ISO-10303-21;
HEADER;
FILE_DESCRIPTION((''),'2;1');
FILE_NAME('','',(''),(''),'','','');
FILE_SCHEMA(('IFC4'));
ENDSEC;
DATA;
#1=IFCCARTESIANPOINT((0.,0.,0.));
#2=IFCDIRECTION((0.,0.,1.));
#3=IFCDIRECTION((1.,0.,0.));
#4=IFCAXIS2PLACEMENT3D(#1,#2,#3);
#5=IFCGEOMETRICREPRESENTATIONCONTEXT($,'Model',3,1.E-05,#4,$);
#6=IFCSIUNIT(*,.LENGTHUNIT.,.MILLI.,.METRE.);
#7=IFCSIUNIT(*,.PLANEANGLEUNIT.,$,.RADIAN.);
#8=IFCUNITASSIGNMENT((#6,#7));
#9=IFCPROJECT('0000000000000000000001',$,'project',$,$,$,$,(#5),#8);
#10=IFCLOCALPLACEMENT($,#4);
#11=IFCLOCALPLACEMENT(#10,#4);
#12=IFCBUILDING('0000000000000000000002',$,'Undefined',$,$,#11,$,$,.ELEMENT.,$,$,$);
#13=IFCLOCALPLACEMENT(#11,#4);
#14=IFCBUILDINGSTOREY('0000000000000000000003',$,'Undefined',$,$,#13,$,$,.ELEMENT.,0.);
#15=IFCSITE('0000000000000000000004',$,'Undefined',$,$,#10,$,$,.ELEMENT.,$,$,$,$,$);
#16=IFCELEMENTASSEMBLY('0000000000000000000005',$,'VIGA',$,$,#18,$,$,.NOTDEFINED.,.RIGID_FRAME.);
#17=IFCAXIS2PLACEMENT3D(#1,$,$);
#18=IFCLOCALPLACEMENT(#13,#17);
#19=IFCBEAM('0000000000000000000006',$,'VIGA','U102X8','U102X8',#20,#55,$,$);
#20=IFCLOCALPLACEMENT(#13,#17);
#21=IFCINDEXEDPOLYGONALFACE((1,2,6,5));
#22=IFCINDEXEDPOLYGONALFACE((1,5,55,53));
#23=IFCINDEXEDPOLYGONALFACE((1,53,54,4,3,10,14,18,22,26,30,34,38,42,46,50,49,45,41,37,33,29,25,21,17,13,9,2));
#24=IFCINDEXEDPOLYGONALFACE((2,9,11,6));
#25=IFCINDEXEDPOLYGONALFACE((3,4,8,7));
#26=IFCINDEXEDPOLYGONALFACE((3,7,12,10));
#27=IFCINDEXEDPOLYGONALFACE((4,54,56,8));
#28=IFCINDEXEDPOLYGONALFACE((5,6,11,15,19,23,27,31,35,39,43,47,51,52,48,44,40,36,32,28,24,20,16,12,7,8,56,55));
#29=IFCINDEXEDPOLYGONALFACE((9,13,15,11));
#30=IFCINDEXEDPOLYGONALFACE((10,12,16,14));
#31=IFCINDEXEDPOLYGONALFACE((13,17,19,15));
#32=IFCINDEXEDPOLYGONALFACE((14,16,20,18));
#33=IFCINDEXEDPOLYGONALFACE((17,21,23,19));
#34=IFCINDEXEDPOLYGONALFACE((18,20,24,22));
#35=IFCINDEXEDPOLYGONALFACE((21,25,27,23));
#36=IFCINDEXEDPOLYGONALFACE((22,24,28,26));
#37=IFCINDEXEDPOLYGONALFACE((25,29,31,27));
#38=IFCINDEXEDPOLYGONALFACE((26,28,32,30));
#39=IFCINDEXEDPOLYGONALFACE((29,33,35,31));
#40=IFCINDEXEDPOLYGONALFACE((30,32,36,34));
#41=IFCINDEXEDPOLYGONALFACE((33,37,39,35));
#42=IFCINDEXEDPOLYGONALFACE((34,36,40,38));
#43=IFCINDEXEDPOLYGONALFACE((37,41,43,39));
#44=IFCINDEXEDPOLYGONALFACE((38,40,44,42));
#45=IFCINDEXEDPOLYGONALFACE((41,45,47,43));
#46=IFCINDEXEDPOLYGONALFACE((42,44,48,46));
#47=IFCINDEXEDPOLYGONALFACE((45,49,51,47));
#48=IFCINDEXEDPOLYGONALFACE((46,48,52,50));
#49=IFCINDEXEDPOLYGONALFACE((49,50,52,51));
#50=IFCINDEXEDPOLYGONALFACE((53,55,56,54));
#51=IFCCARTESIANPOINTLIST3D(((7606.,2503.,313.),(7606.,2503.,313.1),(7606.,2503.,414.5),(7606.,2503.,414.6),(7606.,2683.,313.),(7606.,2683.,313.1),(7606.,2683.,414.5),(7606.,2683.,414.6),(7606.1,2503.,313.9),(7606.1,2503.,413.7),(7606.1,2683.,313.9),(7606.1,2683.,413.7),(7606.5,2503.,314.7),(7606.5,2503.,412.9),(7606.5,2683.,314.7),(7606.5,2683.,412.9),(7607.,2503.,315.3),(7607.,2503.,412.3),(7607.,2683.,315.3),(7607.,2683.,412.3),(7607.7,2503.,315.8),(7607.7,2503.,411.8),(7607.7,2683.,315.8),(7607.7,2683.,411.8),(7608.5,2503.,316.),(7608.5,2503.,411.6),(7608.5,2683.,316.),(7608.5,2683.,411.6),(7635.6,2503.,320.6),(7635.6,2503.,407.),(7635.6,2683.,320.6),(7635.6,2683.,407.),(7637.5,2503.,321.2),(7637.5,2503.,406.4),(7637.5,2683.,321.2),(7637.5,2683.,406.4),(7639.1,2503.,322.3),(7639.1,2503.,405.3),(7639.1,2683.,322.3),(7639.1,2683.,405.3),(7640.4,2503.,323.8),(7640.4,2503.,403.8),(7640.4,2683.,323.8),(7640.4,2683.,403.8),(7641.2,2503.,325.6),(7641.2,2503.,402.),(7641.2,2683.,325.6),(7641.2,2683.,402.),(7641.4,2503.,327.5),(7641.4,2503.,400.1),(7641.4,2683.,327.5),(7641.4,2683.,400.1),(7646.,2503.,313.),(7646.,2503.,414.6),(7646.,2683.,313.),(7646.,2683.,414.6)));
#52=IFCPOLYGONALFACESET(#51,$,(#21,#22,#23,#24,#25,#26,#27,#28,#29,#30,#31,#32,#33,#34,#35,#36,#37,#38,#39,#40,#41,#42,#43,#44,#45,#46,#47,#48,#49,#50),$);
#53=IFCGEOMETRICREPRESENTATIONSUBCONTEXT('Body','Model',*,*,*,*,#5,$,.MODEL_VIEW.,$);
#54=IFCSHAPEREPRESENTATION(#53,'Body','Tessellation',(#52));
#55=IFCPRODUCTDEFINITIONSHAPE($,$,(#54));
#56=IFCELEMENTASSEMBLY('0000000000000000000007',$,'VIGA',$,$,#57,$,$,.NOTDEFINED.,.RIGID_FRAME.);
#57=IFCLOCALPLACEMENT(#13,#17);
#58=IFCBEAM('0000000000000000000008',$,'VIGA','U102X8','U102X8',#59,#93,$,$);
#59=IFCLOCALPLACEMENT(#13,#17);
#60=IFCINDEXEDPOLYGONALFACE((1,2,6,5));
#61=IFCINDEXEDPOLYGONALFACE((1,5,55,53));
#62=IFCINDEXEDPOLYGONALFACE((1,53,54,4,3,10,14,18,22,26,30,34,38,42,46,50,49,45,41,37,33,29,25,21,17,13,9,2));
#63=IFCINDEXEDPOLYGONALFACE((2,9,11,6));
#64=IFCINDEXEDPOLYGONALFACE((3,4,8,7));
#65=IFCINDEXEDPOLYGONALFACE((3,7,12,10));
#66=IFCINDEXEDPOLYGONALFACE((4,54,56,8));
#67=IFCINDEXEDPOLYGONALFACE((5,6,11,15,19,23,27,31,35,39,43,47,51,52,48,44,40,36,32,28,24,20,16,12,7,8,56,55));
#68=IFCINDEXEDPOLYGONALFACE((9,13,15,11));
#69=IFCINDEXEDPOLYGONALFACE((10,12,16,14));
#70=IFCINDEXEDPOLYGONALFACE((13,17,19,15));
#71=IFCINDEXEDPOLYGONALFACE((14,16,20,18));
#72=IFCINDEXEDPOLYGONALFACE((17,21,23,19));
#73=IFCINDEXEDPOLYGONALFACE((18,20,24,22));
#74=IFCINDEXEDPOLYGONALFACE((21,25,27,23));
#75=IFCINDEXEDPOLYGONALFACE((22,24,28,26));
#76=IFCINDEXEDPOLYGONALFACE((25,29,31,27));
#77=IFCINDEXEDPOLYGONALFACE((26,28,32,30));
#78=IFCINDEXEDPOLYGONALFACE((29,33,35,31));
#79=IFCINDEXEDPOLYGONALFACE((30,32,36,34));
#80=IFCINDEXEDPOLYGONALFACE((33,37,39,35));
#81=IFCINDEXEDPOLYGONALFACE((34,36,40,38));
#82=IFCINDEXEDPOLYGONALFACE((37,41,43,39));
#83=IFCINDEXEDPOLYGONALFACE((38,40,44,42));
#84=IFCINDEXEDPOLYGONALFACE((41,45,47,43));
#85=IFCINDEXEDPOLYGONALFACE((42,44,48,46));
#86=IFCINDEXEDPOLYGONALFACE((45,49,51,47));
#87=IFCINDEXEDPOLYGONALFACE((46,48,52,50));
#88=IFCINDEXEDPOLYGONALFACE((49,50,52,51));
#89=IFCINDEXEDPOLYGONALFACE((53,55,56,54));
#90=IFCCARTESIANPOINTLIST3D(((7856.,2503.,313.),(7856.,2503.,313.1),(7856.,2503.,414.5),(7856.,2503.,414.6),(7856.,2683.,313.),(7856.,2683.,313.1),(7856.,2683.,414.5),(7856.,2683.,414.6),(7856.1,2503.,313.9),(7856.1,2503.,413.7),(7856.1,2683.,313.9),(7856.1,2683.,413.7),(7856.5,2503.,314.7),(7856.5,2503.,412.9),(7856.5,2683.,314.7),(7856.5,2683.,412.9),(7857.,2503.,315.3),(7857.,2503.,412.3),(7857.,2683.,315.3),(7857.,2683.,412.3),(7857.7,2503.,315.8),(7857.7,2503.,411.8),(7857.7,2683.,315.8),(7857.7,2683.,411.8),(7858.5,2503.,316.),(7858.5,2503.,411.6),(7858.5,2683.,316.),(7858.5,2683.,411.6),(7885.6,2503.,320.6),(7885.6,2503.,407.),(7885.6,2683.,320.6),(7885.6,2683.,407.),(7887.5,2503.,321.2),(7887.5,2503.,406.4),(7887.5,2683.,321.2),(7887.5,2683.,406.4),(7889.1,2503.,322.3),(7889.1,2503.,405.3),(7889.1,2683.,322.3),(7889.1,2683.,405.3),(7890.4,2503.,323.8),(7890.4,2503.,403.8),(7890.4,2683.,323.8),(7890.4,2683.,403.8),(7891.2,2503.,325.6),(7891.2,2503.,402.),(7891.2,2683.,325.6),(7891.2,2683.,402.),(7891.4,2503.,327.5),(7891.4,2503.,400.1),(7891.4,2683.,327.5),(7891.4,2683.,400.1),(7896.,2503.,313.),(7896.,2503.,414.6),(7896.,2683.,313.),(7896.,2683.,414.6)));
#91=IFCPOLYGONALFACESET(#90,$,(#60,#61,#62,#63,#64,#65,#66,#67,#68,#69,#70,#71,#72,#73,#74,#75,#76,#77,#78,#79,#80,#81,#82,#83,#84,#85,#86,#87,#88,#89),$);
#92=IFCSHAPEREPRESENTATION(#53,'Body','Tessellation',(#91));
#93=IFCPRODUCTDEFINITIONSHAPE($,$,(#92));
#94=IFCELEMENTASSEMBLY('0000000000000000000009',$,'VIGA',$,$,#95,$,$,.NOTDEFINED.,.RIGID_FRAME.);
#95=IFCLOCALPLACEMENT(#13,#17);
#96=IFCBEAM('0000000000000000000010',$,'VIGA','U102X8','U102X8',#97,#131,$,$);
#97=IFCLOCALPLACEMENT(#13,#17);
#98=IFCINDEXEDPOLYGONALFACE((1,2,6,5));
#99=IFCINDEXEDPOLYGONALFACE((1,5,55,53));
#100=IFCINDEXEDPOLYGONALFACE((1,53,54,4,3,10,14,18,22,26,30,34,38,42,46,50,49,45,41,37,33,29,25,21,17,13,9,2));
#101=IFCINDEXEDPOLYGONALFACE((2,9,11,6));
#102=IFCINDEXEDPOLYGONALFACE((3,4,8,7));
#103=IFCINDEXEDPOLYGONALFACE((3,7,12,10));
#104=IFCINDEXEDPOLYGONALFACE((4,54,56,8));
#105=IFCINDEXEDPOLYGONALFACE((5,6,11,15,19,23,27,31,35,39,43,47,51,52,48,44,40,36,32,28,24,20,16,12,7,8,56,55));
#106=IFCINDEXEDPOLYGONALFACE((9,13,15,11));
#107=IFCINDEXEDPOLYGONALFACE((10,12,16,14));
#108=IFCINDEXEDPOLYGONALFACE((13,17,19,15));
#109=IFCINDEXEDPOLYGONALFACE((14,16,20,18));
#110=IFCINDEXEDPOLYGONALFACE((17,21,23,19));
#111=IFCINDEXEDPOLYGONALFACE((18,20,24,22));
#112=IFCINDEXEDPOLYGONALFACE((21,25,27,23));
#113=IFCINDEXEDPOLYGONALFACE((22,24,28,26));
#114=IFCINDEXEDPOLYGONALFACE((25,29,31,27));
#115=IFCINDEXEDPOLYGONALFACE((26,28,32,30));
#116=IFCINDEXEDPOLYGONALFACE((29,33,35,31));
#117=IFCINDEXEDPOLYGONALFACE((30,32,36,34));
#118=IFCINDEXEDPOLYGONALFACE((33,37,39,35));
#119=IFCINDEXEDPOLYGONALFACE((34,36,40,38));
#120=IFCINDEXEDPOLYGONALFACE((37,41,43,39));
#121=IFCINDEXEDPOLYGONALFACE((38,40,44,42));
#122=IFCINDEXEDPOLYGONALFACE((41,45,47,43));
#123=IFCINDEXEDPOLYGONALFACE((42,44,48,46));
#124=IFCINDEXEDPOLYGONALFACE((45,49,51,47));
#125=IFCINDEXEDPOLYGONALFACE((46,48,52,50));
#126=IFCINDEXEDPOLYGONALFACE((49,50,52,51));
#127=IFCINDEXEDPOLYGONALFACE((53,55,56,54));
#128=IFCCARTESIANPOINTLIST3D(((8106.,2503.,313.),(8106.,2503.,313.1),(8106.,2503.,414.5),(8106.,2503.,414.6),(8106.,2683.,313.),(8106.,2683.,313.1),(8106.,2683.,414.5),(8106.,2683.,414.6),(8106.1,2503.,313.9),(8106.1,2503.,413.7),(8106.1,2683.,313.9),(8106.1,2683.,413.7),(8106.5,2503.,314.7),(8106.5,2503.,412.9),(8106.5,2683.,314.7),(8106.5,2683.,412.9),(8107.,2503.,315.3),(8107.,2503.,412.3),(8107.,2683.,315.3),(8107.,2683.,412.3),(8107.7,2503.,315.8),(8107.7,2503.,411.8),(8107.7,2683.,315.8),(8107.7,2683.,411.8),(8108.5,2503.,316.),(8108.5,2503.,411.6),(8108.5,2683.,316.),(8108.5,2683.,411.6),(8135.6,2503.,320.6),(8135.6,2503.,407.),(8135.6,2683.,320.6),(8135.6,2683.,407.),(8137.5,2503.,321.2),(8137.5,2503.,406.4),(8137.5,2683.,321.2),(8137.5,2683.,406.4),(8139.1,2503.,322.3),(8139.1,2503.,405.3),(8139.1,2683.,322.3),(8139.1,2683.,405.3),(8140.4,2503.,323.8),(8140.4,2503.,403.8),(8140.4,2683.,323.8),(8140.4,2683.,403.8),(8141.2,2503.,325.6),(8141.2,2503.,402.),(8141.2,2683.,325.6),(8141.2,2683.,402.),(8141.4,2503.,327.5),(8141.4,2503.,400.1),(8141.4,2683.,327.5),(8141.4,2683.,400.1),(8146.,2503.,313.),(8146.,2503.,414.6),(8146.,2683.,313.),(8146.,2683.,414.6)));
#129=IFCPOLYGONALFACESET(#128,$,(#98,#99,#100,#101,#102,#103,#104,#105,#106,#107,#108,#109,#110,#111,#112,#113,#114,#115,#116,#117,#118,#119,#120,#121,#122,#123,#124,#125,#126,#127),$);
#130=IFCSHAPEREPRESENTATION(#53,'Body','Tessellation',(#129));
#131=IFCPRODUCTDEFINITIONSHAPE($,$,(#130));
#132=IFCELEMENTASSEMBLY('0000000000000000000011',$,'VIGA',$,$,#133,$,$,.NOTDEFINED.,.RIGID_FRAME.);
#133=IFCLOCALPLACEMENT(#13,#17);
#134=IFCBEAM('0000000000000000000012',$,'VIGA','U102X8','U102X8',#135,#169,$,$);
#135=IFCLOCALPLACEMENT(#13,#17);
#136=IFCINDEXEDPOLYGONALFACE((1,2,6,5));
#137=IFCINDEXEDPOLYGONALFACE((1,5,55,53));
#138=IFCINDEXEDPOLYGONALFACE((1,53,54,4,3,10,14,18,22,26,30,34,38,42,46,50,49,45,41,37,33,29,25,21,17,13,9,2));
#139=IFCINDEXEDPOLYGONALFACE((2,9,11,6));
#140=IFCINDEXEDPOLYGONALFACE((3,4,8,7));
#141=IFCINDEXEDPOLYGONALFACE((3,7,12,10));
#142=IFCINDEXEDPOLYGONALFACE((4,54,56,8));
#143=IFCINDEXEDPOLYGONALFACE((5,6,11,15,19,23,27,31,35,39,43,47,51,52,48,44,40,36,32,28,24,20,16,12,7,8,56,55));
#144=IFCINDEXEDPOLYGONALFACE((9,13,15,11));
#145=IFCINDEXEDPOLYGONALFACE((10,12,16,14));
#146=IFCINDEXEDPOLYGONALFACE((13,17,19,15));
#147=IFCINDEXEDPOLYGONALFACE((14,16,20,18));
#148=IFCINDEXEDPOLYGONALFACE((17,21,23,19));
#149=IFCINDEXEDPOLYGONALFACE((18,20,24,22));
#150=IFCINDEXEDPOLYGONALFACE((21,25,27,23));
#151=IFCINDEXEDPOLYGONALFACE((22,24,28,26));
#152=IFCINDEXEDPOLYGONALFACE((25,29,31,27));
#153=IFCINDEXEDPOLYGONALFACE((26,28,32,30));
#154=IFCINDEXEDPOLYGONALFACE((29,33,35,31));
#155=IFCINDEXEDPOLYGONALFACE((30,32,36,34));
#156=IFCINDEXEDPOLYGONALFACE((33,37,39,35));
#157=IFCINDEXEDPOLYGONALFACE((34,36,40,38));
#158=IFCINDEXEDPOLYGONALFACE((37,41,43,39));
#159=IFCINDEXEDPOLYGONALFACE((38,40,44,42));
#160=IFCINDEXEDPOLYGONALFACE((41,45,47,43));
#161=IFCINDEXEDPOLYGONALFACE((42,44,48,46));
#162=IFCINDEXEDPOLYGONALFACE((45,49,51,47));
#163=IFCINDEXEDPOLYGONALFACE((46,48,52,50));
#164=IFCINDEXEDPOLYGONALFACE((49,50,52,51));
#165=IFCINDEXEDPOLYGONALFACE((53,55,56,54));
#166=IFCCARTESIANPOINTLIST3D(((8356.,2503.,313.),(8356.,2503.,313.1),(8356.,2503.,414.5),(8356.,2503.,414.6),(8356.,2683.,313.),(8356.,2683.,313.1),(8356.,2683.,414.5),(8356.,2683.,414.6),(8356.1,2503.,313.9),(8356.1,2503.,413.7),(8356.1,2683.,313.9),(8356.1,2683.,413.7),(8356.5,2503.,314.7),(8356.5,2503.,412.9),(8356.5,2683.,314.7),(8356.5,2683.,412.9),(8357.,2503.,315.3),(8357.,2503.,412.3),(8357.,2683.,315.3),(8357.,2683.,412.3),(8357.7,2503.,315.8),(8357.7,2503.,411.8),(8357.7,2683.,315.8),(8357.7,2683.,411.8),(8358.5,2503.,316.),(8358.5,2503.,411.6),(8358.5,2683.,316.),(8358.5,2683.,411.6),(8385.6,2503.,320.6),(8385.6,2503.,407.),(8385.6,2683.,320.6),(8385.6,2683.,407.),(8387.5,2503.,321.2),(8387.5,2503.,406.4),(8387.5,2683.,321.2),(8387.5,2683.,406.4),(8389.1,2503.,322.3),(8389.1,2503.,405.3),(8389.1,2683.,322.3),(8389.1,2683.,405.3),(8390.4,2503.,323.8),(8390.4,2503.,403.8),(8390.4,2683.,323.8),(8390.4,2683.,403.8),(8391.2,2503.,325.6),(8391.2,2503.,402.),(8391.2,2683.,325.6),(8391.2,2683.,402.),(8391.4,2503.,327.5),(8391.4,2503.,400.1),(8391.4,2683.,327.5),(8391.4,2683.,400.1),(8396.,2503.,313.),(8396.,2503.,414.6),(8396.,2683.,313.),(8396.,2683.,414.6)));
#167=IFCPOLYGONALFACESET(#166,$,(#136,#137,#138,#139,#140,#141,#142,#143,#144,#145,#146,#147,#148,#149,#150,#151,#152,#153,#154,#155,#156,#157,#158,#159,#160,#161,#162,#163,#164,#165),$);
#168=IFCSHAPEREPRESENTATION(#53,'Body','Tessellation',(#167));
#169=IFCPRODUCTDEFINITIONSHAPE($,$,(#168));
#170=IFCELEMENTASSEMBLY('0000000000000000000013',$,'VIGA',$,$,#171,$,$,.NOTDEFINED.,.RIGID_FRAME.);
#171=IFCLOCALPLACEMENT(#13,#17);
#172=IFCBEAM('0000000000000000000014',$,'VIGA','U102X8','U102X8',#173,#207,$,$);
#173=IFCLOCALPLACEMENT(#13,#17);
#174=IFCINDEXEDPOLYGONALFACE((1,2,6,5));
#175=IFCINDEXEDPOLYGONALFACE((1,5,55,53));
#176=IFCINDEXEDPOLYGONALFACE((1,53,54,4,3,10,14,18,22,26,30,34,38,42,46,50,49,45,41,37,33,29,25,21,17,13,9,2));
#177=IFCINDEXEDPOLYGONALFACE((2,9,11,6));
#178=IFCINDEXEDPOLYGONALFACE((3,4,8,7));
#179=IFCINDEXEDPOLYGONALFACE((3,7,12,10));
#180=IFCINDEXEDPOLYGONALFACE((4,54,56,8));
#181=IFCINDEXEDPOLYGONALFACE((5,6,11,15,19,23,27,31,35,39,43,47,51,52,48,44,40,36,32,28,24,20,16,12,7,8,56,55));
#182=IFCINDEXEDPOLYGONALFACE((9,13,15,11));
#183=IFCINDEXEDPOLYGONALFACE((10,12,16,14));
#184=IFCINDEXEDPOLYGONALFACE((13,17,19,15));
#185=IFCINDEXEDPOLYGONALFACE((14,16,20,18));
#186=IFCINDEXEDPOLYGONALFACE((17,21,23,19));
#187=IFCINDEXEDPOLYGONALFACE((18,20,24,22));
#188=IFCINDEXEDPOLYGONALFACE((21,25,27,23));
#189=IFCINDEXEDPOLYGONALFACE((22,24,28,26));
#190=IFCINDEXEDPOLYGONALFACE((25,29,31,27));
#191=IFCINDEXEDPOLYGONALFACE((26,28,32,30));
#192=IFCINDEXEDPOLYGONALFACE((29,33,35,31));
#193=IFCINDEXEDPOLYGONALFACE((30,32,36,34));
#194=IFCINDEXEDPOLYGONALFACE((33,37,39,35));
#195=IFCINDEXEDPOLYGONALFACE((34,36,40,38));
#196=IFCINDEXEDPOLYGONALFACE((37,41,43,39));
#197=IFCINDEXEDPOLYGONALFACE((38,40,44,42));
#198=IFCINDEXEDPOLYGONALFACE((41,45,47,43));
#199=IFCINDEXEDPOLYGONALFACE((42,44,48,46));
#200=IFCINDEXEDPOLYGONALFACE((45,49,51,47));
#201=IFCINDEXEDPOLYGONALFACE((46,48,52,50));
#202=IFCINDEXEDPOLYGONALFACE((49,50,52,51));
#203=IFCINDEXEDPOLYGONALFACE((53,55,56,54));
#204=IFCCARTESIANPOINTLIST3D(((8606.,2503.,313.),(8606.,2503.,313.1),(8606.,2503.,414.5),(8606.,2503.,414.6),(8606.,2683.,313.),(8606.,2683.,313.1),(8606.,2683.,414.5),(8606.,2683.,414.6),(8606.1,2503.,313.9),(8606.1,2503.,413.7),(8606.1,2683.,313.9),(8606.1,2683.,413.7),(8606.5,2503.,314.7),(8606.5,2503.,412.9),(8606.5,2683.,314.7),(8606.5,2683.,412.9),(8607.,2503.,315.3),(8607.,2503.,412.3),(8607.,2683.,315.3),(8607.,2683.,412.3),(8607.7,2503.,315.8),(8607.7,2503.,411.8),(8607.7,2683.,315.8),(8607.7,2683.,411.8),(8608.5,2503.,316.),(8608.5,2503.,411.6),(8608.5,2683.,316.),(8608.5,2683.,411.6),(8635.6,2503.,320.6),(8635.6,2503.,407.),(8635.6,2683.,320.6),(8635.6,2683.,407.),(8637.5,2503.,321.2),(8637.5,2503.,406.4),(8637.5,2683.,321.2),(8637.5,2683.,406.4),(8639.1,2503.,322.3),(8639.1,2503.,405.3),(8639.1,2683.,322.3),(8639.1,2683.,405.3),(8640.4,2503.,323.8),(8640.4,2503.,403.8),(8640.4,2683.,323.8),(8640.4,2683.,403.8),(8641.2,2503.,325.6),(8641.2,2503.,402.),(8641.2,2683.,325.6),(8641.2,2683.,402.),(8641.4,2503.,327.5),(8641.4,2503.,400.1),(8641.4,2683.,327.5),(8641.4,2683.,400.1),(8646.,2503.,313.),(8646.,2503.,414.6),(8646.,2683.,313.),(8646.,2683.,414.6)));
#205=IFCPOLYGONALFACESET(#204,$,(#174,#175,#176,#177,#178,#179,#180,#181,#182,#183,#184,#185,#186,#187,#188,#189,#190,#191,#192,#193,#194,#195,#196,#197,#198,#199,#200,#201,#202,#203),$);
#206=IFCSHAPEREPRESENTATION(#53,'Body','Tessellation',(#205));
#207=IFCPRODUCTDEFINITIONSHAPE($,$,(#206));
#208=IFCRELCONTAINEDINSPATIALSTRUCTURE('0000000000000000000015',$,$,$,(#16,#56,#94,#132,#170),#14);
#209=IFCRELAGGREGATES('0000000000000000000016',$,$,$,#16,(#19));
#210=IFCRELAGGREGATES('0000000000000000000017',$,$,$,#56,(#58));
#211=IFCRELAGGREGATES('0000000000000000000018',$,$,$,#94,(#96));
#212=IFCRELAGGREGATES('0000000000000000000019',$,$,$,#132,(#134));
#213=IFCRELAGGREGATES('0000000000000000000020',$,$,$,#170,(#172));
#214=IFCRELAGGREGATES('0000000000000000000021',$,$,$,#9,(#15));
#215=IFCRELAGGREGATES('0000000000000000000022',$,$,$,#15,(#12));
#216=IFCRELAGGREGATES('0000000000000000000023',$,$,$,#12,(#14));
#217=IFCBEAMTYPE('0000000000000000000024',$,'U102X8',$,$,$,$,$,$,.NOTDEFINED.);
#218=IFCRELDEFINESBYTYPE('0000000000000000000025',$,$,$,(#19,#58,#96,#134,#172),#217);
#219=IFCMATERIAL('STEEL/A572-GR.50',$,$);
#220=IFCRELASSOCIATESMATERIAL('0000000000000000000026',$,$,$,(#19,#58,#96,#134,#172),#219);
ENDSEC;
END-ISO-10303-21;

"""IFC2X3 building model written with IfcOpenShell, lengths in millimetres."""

from ifc_helpers import new_model, si_unit, frame, origin_with_axes, origin_2d_with_axis, place, context, subcontext, project, spatial, u_section, extrude, material, type_object, element, aggregate, save


model = new_model("IFC2X3")

# Units and contexts
model_context = context("Model", 3, precision=1e-05, world=origin_with_axes())
body_context = subcontext(model_context, "Body", "Model", "MODEL_VIEW")
ifc_project = project(units=[si_unit("LENGTHUNIT", "METRE", prefix="MILLI"), si_unit("PLANEANGLEUNIT", "RADIAN")], contexts=[model_context])

# Site, building, storey
site_placement = place(None, origin_with_axes())
site = spatial("IfcSite", under=ifc_project, at=site_placement, Name="Undefined", CompositionType="ELEMENT")
building_placement = place(site_placement, origin_with_axes())
building = spatial("IfcBuilding", under=site, at=building_placement, Name="Undefined", CompositionType="ELEMENT")
storey_placement = place(building_placement, origin_with_axes())
storey = spatial("IfcBuildingStorey", under=building, at=storey_placement, Name="Undefined", CompositionType="ELEMENT", Elevation=0.0)

# Element assemblies, beams
assembly_1_placement = place(storey_placement, origin_with_axes())
assembly_1 = element("IfcElementAssembly", 1, at=assembly_1_placement, inside=storey, Name="VIGA", AssemblyPlace="NOTDEFINED", PredefinedType="RIGID_FRAME")
ifc_material_1 = material(Name="STEEL/A572-GR.50")
beam_type = type_object("IfcBeamType", Name="U102X8", PredefinedType="NOTDEFINED")
beam_1_placement = place(assembly_1_placement, frame((7626.0, 2683.0, 363.8), z_axis=(0.0, 0.0, 1.0), x_axis=(0.0, -1.0, 0.0)))
beam_1 = element("IfcBeam", 2, at=beam_1_placement, type_object=beam_type, material=ifc_material_1, Name="VIGA", Description="U102X8", ObjectType="U102X8", context=body_context, shape_type="SweptSolid", body=[
    extrude(u_section(Depth=101.6, FlangeWidth=40.0, WebThickness=4.6, FlangeThickness=6.0, FilletRadius=7.0, EdgeRadius=3.0, FlangeSlope=0.16839, at=origin_2d_with_axis()), frame((180.0, 0.0, 0.0), z_axis=(-1.0, 0.0, 0.0), x_axis=(0.0, -1.0, 0.0)), (0.0, 0.0, 1.0), 180.0),
])
aggregate(assembly_1, [beam_1])
assembly_2_placement = place(storey_placement, origin_with_axes())
assembly_2 = element("IfcElementAssembly", 3, at=assembly_2_placement, inside=storey, Name="VIGA", AssemblyPlace="NOTDEFINED", PredefinedType="RIGID_FRAME")
beam_2_placement = place(assembly_2_placement, frame((7876.0, 2683.0, 363.8), z_axis=(0.0, 0.0, 1.0), x_axis=(0.0, -1.0, 0.0)))
beam_2 = element("IfcBeam", 4, at=beam_2_placement, type_object=beam_type, material=ifc_material_1, Name="VIGA", Description="U102X8", ObjectType="U102X8", context=body_context, shape_type="SweptSolid", body=[
    extrude(u_section(Depth=101.6, FlangeWidth=40.0, WebThickness=4.6, FlangeThickness=6.0, FilletRadius=7.0, EdgeRadius=3.0, FlangeSlope=0.16839, at=origin_2d_with_axis()), frame((180.0, 0.0, 0.0), z_axis=(-1.0, 0.0, 0.0), x_axis=(0.0, -1.0, 0.0)), (0.0, 0.0, 1.0), 180.0),
])
aggregate(assembly_2, [beam_2])
assembly_3_placement = place(storey_placement, origin_with_axes())
assembly_3 = element("IfcElementAssembly", 5, at=assembly_3_placement, inside=storey, Name="VIGA", AssemblyPlace="NOTDEFINED", PredefinedType="RIGID_FRAME")
beam_3_placement = place(assembly_3_placement, frame((8126.0, 2683.0, 363.8), z_axis=(0.0, 0.0, 1.0), x_axis=(0.0, -1.0, 0.0)))
beam_3 = element("IfcBeam", 6, at=beam_3_placement, type_object=beam_type, material=ifc_material_1, Name="VIGA", Description="U102X8", ObjectType="U102X8", context=body_context, shape_type="SweptSolid", body=[
    extrude(u_section(Depth=101.6, FlangeWidth=40.0, WebThickness=4.6, FlangeThickness=6.0, FilletRadius=7.0, EdgeRadius=3.0, FlangeSlope=0.16839, at=origin_2d_with_axis()), frame((180.0, 0.0, 0.0), z_axis=(-1.0, 0.0, 0.0), x_axis=(0.0, -1.0, 0.0)), (0.0, 0.0, 1.0), 180.0),
])
aggregate(assembly_3, [beam_3])
assembly_4_placement = place(storey_placement, origin_with_axes())
assembly_4 = element("IfcElementAssembly", 7, at=assembly_4_placement, inside=storey, Name="VIGA", AssemblyPlace="NOTDEFINED", PredefinedType="RIGID_FRAME")
beam_4_placement = place(assembly_4_placement, frame((8376.0, 2683.0, 363.8), z_axis=(0.0, 0.0, 1.0), x_axis=(0.0, -1.0, 0.0)))
beam_4 = element("IfcBeam", 8, at=beam_4_placement, type_object=beam_type, material=ifc_material_1, Name="VIGA", Description="U102X8", ObjectType="U102X8", context=body_context, shape_type="SweptSolid", body=[
    extrude(u_section(Depth=101.6, FlangeWidth=40.0, WebThickness=4.6, FlangeThickness=6.0, FilletRadius=7.0, EdgeRadius=3.0, FlangeSlope=0.16839, at=origin_2d_with_axis()), frame((180.0, 0.0, 0.0), z_axis=(-1.0, 0.0, 0.0), x_axis=(0.0, -1.0, 0.0)), (0.0, 0.0, 1.0), 180.0),
])
aggregate(assembly_4, [beam_4])
assembly_5_placement = place(storey_placement, origin_with_axes())
assembly_5 = element("IfcElementAssembly", 9, at=assembly_5_placement, inside=storey, Name="VIGA", AssemblyPlace="NOTDEFINED", PredefinedType="RIGID_FRAME")
beam_5_placement = place(assembly_5_placement, frame((8626.0, 2683.0, 363.8), z_axis=(0.0, 0.0, 1.0), x_axis=(0.0, -1.0, 0.0)))
beam_5 = element("IfcBeam", 10, at=beam_5_placement, type_object=beam_type, material=ifc_material_1, Name="VIGA", Description="U102X8", ObjectType="U102X8", context=body_context, shape_type="SweptSolid", body=[
    extrude(u_section(Depth=101.6, FlangeWidth=40.0, WebThickness=4.6, FlangeThickness=6.0, FilletRadius=7.0, EdgeRadius=3.0, FlangeSlope=0.16839, at=origin_2d_with_axis()), frame((180.0, 0.0, 0.0), z_axis=(-1.0, 0.0, 0.0), x_axis=(0.0, -1.0, 0.0)), (0.0, 0.0, 1.0), 180.0),
])
aggregate(assembly_5, [beam_5])

save(model, "model.ifc")
